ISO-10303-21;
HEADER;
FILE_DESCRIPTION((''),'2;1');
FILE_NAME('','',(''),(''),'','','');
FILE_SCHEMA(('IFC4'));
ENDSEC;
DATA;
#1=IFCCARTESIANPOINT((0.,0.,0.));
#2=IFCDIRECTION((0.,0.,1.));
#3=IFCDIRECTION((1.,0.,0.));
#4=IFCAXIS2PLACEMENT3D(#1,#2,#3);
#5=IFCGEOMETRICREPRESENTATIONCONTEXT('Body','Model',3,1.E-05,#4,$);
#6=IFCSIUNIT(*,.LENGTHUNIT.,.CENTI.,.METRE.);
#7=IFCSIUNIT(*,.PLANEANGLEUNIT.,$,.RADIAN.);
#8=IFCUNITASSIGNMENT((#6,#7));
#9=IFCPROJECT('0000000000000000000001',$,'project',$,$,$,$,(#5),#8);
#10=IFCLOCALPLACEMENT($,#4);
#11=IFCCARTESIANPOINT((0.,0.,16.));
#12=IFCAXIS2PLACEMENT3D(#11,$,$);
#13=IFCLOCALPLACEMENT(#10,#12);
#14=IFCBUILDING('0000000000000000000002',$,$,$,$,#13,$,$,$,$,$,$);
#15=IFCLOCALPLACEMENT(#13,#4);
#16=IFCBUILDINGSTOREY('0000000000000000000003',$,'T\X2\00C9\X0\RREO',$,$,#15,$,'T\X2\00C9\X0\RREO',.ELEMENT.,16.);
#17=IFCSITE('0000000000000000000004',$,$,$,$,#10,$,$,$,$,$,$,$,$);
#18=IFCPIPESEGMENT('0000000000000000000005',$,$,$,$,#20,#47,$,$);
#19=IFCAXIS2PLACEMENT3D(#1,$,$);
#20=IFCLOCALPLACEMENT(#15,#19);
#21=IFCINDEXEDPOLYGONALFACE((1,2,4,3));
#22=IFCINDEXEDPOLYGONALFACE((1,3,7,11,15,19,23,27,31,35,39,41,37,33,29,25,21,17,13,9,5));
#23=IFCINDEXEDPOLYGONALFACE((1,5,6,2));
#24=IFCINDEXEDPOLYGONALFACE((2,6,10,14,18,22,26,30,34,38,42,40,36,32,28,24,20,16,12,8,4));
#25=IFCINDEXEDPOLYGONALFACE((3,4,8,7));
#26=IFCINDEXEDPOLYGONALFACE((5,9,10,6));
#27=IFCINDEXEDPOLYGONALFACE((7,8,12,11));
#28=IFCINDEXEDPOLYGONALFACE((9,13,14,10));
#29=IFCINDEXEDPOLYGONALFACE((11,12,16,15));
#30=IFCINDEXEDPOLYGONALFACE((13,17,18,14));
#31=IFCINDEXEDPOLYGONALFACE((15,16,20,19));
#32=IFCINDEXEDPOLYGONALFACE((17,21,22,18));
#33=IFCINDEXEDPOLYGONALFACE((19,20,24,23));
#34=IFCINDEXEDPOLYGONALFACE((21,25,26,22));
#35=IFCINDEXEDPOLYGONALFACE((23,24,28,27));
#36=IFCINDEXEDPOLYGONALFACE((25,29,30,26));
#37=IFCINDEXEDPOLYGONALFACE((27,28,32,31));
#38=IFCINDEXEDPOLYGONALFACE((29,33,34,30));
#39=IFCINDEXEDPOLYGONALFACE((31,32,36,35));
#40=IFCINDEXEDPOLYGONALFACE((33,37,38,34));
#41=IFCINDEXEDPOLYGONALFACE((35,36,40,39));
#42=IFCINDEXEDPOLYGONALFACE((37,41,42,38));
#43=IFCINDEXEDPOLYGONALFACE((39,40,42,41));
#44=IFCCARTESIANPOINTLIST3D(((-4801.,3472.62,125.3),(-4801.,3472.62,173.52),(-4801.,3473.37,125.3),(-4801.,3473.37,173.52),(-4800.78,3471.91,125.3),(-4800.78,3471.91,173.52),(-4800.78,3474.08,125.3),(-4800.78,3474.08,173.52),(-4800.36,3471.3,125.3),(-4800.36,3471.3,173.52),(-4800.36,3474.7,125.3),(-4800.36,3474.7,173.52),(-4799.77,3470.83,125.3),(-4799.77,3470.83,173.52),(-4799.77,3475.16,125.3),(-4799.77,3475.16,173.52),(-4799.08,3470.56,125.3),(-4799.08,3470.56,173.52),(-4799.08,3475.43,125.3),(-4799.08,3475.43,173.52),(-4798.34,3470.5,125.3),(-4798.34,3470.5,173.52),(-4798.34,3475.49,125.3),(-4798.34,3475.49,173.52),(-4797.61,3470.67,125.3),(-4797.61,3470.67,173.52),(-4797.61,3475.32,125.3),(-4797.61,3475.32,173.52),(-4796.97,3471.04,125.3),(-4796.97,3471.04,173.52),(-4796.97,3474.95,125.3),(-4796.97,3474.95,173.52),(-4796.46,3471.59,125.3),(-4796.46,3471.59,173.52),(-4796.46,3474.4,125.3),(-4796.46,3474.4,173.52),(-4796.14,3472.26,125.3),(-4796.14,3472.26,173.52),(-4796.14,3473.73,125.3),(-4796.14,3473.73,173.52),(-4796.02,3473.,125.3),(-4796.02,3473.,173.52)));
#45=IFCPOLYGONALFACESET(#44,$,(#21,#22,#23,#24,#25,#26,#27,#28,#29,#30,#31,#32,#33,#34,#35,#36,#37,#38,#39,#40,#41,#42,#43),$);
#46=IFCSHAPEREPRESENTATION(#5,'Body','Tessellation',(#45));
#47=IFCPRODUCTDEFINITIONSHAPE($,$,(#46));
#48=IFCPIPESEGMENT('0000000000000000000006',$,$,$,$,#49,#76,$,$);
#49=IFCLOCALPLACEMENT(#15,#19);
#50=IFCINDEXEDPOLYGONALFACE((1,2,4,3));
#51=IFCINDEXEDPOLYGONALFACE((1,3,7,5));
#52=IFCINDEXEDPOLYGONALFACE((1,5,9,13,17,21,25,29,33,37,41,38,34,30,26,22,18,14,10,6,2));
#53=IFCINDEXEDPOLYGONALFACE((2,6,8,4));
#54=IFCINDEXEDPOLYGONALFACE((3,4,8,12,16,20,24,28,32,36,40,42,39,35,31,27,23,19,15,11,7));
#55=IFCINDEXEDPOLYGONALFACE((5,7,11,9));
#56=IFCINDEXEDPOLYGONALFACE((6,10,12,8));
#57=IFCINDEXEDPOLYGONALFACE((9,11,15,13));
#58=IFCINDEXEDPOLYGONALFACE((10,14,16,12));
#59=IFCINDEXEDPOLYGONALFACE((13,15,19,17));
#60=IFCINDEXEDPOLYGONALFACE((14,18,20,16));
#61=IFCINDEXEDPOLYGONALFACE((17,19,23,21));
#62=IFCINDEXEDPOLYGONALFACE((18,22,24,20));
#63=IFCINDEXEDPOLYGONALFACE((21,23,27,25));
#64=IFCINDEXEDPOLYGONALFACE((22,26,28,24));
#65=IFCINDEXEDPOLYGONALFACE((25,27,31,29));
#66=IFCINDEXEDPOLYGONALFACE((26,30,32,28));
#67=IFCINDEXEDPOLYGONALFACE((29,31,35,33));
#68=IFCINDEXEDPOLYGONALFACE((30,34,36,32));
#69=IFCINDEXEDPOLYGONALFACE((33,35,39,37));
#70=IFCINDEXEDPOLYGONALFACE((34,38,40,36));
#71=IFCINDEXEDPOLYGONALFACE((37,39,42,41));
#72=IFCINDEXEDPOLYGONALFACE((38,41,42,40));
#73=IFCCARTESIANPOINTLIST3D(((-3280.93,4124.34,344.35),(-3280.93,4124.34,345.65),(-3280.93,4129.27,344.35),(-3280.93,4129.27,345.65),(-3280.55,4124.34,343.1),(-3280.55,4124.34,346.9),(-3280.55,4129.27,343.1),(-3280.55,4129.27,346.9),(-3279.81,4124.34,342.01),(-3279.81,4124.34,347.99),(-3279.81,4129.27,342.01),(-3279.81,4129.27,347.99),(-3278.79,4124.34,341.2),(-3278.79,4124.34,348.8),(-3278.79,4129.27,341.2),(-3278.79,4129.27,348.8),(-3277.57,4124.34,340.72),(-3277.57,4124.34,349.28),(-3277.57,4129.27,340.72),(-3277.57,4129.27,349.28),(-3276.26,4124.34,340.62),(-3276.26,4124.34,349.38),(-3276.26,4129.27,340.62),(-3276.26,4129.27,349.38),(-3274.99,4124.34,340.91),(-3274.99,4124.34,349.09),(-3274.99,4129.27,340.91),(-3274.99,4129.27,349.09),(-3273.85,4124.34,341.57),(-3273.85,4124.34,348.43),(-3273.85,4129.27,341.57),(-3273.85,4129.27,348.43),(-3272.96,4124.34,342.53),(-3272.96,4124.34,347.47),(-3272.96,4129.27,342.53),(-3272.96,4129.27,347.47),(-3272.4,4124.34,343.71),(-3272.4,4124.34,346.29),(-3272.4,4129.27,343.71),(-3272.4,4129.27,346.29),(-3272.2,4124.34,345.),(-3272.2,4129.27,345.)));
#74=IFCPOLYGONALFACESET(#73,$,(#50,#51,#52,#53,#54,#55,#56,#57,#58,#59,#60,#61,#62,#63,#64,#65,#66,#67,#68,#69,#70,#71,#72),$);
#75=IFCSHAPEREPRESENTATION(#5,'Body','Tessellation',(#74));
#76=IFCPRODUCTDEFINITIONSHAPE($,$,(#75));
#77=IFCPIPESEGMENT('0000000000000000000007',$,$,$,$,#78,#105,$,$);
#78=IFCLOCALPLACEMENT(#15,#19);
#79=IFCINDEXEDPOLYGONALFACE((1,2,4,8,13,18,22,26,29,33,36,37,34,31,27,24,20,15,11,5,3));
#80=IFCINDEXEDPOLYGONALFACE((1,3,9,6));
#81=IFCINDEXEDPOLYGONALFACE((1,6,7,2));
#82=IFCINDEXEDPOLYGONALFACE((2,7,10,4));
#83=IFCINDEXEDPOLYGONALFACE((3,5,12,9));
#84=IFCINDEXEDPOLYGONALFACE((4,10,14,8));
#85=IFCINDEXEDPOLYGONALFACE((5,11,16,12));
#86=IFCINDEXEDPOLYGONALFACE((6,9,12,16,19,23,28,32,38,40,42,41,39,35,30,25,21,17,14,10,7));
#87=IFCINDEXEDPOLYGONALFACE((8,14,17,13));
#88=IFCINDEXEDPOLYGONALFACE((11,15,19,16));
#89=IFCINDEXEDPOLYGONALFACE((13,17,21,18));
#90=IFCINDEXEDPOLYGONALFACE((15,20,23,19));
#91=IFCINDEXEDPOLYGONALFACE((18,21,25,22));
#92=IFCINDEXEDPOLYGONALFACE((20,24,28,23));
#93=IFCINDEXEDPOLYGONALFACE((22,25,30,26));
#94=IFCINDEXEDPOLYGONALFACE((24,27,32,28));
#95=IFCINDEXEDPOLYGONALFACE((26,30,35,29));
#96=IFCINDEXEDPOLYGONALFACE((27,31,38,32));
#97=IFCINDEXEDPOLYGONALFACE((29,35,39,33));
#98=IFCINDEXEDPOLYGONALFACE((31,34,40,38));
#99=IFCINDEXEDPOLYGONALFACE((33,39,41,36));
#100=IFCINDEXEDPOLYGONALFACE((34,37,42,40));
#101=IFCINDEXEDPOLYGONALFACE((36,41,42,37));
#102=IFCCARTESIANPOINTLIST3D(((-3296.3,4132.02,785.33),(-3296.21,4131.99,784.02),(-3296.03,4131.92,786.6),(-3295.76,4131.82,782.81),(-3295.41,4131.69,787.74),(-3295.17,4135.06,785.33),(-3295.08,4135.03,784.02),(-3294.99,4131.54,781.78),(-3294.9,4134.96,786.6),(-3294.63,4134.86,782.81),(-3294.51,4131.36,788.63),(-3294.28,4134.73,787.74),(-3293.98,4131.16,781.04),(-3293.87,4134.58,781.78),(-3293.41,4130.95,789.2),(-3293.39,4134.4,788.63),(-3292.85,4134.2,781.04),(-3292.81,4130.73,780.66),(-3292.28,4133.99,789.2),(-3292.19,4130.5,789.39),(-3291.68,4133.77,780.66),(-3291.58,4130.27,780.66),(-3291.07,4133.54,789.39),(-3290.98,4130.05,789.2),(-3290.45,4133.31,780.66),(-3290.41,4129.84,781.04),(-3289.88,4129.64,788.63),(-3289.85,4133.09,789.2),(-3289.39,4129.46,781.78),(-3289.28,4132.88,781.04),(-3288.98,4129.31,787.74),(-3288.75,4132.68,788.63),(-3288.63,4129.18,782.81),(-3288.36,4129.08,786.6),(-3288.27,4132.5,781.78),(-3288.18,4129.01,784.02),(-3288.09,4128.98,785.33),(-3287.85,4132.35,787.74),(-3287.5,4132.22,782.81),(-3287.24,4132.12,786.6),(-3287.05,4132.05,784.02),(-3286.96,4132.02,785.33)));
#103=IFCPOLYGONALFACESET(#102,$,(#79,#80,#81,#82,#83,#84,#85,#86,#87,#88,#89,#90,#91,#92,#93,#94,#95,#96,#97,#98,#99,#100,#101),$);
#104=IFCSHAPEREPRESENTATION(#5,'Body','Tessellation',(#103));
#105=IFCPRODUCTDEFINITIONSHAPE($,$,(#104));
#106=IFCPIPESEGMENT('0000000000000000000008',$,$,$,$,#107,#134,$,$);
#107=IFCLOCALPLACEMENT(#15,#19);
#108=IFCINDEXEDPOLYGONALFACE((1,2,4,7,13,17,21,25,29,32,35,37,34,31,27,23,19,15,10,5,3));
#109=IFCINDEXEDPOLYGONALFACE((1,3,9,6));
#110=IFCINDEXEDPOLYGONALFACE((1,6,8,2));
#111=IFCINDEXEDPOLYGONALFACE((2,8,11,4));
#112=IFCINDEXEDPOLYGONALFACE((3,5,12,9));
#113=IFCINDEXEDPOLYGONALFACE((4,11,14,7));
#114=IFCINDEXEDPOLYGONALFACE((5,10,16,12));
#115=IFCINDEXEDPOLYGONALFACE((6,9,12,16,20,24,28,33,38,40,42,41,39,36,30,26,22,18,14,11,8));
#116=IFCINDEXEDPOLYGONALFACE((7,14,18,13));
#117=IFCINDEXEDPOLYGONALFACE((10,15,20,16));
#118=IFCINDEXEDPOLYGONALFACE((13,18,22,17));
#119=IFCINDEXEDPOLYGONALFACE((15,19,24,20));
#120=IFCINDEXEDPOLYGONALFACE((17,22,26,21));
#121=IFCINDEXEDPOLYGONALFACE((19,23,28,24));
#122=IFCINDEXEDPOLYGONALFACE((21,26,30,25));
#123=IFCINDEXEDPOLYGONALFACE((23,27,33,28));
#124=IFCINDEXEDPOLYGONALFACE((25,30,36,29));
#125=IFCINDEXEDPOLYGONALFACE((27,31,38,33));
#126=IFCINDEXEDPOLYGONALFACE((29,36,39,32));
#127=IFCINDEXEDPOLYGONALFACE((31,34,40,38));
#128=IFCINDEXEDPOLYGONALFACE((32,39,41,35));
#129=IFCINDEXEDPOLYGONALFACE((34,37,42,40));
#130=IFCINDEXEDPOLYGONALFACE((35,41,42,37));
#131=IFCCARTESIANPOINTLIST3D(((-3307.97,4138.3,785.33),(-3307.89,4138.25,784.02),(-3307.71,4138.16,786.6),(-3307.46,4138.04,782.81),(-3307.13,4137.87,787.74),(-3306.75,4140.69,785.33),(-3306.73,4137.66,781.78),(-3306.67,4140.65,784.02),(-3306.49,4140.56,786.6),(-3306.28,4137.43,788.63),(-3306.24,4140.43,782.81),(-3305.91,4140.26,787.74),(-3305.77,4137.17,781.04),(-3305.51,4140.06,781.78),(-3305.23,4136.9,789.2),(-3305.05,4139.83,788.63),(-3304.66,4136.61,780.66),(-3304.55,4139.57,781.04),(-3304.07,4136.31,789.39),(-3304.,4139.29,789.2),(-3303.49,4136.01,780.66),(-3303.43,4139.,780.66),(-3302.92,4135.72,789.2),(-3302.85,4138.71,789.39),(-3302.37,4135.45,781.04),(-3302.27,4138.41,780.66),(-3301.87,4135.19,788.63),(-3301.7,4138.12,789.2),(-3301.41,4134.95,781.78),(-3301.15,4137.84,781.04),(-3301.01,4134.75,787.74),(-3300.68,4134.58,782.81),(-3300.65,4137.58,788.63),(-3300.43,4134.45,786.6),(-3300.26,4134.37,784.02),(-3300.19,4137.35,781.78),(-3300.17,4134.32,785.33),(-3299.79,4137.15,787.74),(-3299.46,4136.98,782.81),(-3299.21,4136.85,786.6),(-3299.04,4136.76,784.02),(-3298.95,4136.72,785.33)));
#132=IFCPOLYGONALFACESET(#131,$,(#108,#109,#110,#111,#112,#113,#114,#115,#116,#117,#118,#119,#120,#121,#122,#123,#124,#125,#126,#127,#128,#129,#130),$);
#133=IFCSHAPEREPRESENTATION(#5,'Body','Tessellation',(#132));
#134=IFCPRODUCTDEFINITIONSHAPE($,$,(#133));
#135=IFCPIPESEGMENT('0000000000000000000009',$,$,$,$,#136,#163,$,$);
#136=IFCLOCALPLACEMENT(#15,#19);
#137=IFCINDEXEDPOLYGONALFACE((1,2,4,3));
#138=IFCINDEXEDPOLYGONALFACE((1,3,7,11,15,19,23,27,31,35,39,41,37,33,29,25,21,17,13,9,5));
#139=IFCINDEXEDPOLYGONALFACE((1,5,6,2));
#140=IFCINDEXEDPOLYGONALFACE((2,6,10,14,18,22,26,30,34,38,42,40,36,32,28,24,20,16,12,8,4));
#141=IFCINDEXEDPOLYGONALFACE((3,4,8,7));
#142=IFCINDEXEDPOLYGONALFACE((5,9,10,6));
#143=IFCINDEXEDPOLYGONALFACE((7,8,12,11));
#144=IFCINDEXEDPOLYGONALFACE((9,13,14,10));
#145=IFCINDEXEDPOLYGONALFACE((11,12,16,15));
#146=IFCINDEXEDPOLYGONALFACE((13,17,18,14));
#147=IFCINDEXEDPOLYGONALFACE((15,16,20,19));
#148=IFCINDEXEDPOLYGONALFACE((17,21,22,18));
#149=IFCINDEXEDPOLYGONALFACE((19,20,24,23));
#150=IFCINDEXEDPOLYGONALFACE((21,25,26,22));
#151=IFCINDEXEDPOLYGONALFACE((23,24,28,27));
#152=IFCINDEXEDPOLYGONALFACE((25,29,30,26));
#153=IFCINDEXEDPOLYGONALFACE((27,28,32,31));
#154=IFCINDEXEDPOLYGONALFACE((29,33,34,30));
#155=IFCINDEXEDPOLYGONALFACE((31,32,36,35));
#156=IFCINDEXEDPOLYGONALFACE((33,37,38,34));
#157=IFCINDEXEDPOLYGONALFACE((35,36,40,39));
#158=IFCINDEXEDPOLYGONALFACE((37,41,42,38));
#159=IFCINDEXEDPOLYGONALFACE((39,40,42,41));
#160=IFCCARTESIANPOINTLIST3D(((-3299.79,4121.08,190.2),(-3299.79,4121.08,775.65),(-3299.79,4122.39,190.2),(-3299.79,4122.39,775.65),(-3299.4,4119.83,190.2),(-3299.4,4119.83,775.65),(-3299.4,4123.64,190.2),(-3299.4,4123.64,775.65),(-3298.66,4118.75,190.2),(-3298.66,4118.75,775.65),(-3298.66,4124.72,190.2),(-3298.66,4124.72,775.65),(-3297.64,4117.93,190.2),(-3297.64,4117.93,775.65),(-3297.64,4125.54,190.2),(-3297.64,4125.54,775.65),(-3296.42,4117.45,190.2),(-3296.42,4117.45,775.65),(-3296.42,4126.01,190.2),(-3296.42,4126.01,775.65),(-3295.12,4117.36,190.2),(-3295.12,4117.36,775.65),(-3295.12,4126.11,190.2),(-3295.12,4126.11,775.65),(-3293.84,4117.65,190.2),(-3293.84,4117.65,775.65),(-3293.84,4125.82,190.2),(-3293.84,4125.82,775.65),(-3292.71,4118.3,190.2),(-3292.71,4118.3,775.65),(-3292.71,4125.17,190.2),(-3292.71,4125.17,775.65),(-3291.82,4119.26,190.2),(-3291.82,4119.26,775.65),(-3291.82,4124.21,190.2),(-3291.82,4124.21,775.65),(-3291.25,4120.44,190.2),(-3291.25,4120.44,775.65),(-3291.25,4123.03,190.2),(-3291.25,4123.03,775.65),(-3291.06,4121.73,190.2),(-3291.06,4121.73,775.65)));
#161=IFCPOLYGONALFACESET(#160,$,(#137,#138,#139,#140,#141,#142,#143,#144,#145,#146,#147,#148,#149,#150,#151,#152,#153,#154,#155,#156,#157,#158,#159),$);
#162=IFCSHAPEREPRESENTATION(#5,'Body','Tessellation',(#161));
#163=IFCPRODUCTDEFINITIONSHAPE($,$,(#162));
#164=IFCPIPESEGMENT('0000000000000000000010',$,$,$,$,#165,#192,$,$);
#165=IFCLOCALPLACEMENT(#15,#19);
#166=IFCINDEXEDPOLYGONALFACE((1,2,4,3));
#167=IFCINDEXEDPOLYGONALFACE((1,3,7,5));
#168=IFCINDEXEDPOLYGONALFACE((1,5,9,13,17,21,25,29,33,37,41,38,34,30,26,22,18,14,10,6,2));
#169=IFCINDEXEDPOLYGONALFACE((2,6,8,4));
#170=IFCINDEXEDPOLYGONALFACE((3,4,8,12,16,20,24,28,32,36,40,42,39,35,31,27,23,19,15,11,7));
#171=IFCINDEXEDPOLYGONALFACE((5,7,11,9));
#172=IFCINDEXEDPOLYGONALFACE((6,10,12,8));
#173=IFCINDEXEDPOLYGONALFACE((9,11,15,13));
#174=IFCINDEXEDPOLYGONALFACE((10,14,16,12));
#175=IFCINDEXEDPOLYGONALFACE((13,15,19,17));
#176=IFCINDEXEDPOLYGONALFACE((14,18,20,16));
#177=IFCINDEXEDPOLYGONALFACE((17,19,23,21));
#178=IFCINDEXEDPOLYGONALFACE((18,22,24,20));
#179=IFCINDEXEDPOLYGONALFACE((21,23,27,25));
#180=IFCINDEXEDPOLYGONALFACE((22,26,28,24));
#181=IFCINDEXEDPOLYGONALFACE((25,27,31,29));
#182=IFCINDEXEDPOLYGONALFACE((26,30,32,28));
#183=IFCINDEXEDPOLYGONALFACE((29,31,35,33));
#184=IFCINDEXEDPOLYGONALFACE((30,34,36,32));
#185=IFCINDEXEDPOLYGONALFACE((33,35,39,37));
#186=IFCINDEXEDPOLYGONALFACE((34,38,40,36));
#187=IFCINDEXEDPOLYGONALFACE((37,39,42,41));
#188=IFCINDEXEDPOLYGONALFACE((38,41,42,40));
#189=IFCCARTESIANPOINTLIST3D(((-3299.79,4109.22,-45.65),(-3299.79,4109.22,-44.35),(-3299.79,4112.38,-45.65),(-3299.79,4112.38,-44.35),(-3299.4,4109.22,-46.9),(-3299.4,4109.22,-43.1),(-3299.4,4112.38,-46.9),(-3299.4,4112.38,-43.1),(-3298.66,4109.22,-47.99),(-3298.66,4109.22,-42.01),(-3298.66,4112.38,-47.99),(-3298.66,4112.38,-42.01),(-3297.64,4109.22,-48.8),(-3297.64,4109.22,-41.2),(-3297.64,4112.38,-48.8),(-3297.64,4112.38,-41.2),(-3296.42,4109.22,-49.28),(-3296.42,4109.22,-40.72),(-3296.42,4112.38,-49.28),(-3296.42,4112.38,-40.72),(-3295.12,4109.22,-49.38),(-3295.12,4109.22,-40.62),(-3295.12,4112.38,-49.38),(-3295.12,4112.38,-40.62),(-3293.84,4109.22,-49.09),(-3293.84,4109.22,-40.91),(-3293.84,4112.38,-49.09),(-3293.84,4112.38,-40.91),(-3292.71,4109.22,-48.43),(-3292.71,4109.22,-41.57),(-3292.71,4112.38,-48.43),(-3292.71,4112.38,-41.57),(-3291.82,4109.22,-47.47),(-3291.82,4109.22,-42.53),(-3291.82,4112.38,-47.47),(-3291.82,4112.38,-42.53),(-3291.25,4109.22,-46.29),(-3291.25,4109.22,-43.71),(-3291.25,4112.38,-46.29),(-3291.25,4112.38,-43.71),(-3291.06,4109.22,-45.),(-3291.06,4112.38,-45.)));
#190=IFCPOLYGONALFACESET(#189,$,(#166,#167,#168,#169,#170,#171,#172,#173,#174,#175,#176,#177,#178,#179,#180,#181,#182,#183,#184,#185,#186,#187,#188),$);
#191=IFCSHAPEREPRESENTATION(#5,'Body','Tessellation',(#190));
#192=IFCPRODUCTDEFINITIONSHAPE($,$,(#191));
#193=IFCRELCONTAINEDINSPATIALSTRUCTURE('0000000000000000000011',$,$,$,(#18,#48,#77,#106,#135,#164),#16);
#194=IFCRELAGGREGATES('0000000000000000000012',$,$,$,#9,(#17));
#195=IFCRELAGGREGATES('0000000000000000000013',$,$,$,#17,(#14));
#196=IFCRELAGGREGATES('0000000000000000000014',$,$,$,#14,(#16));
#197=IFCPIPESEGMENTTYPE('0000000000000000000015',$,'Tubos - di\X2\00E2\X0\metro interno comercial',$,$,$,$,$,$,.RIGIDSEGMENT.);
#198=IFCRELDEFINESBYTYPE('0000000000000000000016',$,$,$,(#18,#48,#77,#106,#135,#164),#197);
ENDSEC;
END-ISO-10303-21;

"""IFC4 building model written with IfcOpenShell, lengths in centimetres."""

from ifc_helpers import new_model, si_unit, frame, origin_with_axes, origin_2d_with_axis, place, context, project, spatial, circle, extrude, type_object, element, save


model = new_model("IFC4")

# Units and contexts
model_context = context("Model", 3, precision=1e-05, world=origin_with_axes(), identifier="Body")
ifc_project = project(units=[si_unit("LENGTHUNIT", "METRE", prefix="CENTI"), si_unit("PLANEANGLEUNIT", "RADIAN")], contexts=[model_context])

# Site, building, storey
site_placement = place(None, origin_with_axes())
site = spatial("IfcSite", under=ifc_project, at=site_placement)
building_placement = place(site_placement, frame((0.0, 0.0, 16.0)))
building = spatial("IfcBuilding", under=site, at=building_placement)
storey_placement = place(building_placement, origin_with_axes())
storey = spatial("IfcBuildingStorey", under=building, at=storey_placement, Name="TÉRREO", LongName="TÉRREO", CompositionType="ELEMENT", Elevation=16.0)

# Pipe segments
pipe_segment_type = type_object("IfcPipeSegmentType", Name="Tubos - diâmetro interno comercial", PredefinedType="RIGIDSEGMENT")
pipe_segment_1_placement = place(storey_placement, frame((-4798.52, 3473.0, 173.52), z_axis=(0.0, 0.0, 1.0), x_axis=(1.0, 0.0, 0.0)))
element("IfcPipeSegment", 1, at=pipe_segment_1_placement, inside=storey, type_object=pipe_segment_type, context=model_context, shape_type="SolidModel", body=[
    extrude(circle(Radius=2.5, at=origin_2d_with_axis()), frame((0.0, 0.0, 0.0), z_axis=(0.0, 0.0, -1.0), x_axis=(1.0, 0.0, 0.0)), (0.0, 0.0, 1.0), 48.22),
])
pipe_segment_2_placement = place(storey_placement, frame((-3276.59, 4126.8, 349.39), z_axis=(0.0, 0.0, 1.0), x_axis=(1.0, 0.0, 0.0)))
element("IfcPipeSegment", 2, at=pipe_segment_2_placement, inside=storey, type_object=pipe_segment_type, context=model_context, shape_type="SolidModel", body=[
    extrude(circle(Radius=4.39, at=origin_2d_with_axis()), frame((0.0, 2.46, -4.39), z_axis=(0.0, -1.0, 0.0), x_axis=(1.0, 0.0, 0.0)), (0.0, 0.0, 1.0), 4.93),
])
pipe_segment_3_placement = place(storey_placement, frame((-3291.63, 4132.02, 789.39), z_axis=(0.0, 0.0, 1.0), x_axis=(1.0, 0.0, 0.0)))
element("IfcPipeSegment", 3, at=pipe_segment_3_placement, inside=storey, type_object=pipe_segment_type, context=model_context, shape_type="SolidModel", body=[
    extrude(circle(Radius=4.39, at=origin_2d_with_axis()), frame((0.56, 1.52, -4.39), z_axis=(-0.347683, -0.937612, 0.0), x_axis=(0.0, 0.0, 1.0)), (0.0, 0.0, 1.0), 3.24),
])
pipe_segment_4_placement = place(storey_placement, frame((-3303.46, 4137.51, 789.39), z_axis=(0.0, 0.0, 1.0), x_axis=(1.0, 0.0, 0.0)))
element("IfcPipeSegment", 4, at=pipe_segment_4_placement, inside=storey, type_object=pipe_segment_type, context=model_context, shape_type="SolidModel", body=[
    extrude(circle(Radius=4.39, at=origin_2d_with_axis()), frame((0.61, 1.2, -4.39), z_axis=(-0.453851, -0.891078, 0.0), x_axis=(0.0, 0.0, 1.0)), (0.0, 0.0, 1.0), 2.69),
])
pipe_segment_5_placement = place(storey_placement, frame((-3295.45, 4121.73, 775.65), z_axis=(0.0, 0.0, 1.0), x_axis=(1.0, 0.0, 0.0)))
element("IfcPipeSegment", 5, at=pipe_segment_5_placement, inside=storey, type_object=pipe_segment_type, context=model_context, shape_type="SolidModel", body=[
    extrude(circle(Radius=4.39, at=origin_2d_with_axis()), frame((0.0, 0.0, 0.0), z_axis=(0.0, 0.0, -1.0), x_axis=(1.0, 0.0, 0.0)), (0.0, 0.0, 1.0), 585.45),
])
pipe_segment_6_placement = place(storey_placement, frame((-3295.45, 4110.8, -40.61), z_axis=(0.0, 0.0, 1.0), x_axis=(1.0, 0.0, 0.0)))
element("IfcPipeSegment", 6, at=pipe_segment_6_placement, inside=storey, type_object=pipe_segment_type, context=model_context, shape_type="SolidModel", body=[
    extrude(circle(Radius=4.39, at=origin_2d_with_axis()), frame((0.0, 1.58, -4.39), z_axis=(0.0, -1.0, 0.0), x_axis=(1.0, 0.0, 0.0)), (0.0, 0.0, 1.0), 3.16),
])

save(model, "model.ifc")
